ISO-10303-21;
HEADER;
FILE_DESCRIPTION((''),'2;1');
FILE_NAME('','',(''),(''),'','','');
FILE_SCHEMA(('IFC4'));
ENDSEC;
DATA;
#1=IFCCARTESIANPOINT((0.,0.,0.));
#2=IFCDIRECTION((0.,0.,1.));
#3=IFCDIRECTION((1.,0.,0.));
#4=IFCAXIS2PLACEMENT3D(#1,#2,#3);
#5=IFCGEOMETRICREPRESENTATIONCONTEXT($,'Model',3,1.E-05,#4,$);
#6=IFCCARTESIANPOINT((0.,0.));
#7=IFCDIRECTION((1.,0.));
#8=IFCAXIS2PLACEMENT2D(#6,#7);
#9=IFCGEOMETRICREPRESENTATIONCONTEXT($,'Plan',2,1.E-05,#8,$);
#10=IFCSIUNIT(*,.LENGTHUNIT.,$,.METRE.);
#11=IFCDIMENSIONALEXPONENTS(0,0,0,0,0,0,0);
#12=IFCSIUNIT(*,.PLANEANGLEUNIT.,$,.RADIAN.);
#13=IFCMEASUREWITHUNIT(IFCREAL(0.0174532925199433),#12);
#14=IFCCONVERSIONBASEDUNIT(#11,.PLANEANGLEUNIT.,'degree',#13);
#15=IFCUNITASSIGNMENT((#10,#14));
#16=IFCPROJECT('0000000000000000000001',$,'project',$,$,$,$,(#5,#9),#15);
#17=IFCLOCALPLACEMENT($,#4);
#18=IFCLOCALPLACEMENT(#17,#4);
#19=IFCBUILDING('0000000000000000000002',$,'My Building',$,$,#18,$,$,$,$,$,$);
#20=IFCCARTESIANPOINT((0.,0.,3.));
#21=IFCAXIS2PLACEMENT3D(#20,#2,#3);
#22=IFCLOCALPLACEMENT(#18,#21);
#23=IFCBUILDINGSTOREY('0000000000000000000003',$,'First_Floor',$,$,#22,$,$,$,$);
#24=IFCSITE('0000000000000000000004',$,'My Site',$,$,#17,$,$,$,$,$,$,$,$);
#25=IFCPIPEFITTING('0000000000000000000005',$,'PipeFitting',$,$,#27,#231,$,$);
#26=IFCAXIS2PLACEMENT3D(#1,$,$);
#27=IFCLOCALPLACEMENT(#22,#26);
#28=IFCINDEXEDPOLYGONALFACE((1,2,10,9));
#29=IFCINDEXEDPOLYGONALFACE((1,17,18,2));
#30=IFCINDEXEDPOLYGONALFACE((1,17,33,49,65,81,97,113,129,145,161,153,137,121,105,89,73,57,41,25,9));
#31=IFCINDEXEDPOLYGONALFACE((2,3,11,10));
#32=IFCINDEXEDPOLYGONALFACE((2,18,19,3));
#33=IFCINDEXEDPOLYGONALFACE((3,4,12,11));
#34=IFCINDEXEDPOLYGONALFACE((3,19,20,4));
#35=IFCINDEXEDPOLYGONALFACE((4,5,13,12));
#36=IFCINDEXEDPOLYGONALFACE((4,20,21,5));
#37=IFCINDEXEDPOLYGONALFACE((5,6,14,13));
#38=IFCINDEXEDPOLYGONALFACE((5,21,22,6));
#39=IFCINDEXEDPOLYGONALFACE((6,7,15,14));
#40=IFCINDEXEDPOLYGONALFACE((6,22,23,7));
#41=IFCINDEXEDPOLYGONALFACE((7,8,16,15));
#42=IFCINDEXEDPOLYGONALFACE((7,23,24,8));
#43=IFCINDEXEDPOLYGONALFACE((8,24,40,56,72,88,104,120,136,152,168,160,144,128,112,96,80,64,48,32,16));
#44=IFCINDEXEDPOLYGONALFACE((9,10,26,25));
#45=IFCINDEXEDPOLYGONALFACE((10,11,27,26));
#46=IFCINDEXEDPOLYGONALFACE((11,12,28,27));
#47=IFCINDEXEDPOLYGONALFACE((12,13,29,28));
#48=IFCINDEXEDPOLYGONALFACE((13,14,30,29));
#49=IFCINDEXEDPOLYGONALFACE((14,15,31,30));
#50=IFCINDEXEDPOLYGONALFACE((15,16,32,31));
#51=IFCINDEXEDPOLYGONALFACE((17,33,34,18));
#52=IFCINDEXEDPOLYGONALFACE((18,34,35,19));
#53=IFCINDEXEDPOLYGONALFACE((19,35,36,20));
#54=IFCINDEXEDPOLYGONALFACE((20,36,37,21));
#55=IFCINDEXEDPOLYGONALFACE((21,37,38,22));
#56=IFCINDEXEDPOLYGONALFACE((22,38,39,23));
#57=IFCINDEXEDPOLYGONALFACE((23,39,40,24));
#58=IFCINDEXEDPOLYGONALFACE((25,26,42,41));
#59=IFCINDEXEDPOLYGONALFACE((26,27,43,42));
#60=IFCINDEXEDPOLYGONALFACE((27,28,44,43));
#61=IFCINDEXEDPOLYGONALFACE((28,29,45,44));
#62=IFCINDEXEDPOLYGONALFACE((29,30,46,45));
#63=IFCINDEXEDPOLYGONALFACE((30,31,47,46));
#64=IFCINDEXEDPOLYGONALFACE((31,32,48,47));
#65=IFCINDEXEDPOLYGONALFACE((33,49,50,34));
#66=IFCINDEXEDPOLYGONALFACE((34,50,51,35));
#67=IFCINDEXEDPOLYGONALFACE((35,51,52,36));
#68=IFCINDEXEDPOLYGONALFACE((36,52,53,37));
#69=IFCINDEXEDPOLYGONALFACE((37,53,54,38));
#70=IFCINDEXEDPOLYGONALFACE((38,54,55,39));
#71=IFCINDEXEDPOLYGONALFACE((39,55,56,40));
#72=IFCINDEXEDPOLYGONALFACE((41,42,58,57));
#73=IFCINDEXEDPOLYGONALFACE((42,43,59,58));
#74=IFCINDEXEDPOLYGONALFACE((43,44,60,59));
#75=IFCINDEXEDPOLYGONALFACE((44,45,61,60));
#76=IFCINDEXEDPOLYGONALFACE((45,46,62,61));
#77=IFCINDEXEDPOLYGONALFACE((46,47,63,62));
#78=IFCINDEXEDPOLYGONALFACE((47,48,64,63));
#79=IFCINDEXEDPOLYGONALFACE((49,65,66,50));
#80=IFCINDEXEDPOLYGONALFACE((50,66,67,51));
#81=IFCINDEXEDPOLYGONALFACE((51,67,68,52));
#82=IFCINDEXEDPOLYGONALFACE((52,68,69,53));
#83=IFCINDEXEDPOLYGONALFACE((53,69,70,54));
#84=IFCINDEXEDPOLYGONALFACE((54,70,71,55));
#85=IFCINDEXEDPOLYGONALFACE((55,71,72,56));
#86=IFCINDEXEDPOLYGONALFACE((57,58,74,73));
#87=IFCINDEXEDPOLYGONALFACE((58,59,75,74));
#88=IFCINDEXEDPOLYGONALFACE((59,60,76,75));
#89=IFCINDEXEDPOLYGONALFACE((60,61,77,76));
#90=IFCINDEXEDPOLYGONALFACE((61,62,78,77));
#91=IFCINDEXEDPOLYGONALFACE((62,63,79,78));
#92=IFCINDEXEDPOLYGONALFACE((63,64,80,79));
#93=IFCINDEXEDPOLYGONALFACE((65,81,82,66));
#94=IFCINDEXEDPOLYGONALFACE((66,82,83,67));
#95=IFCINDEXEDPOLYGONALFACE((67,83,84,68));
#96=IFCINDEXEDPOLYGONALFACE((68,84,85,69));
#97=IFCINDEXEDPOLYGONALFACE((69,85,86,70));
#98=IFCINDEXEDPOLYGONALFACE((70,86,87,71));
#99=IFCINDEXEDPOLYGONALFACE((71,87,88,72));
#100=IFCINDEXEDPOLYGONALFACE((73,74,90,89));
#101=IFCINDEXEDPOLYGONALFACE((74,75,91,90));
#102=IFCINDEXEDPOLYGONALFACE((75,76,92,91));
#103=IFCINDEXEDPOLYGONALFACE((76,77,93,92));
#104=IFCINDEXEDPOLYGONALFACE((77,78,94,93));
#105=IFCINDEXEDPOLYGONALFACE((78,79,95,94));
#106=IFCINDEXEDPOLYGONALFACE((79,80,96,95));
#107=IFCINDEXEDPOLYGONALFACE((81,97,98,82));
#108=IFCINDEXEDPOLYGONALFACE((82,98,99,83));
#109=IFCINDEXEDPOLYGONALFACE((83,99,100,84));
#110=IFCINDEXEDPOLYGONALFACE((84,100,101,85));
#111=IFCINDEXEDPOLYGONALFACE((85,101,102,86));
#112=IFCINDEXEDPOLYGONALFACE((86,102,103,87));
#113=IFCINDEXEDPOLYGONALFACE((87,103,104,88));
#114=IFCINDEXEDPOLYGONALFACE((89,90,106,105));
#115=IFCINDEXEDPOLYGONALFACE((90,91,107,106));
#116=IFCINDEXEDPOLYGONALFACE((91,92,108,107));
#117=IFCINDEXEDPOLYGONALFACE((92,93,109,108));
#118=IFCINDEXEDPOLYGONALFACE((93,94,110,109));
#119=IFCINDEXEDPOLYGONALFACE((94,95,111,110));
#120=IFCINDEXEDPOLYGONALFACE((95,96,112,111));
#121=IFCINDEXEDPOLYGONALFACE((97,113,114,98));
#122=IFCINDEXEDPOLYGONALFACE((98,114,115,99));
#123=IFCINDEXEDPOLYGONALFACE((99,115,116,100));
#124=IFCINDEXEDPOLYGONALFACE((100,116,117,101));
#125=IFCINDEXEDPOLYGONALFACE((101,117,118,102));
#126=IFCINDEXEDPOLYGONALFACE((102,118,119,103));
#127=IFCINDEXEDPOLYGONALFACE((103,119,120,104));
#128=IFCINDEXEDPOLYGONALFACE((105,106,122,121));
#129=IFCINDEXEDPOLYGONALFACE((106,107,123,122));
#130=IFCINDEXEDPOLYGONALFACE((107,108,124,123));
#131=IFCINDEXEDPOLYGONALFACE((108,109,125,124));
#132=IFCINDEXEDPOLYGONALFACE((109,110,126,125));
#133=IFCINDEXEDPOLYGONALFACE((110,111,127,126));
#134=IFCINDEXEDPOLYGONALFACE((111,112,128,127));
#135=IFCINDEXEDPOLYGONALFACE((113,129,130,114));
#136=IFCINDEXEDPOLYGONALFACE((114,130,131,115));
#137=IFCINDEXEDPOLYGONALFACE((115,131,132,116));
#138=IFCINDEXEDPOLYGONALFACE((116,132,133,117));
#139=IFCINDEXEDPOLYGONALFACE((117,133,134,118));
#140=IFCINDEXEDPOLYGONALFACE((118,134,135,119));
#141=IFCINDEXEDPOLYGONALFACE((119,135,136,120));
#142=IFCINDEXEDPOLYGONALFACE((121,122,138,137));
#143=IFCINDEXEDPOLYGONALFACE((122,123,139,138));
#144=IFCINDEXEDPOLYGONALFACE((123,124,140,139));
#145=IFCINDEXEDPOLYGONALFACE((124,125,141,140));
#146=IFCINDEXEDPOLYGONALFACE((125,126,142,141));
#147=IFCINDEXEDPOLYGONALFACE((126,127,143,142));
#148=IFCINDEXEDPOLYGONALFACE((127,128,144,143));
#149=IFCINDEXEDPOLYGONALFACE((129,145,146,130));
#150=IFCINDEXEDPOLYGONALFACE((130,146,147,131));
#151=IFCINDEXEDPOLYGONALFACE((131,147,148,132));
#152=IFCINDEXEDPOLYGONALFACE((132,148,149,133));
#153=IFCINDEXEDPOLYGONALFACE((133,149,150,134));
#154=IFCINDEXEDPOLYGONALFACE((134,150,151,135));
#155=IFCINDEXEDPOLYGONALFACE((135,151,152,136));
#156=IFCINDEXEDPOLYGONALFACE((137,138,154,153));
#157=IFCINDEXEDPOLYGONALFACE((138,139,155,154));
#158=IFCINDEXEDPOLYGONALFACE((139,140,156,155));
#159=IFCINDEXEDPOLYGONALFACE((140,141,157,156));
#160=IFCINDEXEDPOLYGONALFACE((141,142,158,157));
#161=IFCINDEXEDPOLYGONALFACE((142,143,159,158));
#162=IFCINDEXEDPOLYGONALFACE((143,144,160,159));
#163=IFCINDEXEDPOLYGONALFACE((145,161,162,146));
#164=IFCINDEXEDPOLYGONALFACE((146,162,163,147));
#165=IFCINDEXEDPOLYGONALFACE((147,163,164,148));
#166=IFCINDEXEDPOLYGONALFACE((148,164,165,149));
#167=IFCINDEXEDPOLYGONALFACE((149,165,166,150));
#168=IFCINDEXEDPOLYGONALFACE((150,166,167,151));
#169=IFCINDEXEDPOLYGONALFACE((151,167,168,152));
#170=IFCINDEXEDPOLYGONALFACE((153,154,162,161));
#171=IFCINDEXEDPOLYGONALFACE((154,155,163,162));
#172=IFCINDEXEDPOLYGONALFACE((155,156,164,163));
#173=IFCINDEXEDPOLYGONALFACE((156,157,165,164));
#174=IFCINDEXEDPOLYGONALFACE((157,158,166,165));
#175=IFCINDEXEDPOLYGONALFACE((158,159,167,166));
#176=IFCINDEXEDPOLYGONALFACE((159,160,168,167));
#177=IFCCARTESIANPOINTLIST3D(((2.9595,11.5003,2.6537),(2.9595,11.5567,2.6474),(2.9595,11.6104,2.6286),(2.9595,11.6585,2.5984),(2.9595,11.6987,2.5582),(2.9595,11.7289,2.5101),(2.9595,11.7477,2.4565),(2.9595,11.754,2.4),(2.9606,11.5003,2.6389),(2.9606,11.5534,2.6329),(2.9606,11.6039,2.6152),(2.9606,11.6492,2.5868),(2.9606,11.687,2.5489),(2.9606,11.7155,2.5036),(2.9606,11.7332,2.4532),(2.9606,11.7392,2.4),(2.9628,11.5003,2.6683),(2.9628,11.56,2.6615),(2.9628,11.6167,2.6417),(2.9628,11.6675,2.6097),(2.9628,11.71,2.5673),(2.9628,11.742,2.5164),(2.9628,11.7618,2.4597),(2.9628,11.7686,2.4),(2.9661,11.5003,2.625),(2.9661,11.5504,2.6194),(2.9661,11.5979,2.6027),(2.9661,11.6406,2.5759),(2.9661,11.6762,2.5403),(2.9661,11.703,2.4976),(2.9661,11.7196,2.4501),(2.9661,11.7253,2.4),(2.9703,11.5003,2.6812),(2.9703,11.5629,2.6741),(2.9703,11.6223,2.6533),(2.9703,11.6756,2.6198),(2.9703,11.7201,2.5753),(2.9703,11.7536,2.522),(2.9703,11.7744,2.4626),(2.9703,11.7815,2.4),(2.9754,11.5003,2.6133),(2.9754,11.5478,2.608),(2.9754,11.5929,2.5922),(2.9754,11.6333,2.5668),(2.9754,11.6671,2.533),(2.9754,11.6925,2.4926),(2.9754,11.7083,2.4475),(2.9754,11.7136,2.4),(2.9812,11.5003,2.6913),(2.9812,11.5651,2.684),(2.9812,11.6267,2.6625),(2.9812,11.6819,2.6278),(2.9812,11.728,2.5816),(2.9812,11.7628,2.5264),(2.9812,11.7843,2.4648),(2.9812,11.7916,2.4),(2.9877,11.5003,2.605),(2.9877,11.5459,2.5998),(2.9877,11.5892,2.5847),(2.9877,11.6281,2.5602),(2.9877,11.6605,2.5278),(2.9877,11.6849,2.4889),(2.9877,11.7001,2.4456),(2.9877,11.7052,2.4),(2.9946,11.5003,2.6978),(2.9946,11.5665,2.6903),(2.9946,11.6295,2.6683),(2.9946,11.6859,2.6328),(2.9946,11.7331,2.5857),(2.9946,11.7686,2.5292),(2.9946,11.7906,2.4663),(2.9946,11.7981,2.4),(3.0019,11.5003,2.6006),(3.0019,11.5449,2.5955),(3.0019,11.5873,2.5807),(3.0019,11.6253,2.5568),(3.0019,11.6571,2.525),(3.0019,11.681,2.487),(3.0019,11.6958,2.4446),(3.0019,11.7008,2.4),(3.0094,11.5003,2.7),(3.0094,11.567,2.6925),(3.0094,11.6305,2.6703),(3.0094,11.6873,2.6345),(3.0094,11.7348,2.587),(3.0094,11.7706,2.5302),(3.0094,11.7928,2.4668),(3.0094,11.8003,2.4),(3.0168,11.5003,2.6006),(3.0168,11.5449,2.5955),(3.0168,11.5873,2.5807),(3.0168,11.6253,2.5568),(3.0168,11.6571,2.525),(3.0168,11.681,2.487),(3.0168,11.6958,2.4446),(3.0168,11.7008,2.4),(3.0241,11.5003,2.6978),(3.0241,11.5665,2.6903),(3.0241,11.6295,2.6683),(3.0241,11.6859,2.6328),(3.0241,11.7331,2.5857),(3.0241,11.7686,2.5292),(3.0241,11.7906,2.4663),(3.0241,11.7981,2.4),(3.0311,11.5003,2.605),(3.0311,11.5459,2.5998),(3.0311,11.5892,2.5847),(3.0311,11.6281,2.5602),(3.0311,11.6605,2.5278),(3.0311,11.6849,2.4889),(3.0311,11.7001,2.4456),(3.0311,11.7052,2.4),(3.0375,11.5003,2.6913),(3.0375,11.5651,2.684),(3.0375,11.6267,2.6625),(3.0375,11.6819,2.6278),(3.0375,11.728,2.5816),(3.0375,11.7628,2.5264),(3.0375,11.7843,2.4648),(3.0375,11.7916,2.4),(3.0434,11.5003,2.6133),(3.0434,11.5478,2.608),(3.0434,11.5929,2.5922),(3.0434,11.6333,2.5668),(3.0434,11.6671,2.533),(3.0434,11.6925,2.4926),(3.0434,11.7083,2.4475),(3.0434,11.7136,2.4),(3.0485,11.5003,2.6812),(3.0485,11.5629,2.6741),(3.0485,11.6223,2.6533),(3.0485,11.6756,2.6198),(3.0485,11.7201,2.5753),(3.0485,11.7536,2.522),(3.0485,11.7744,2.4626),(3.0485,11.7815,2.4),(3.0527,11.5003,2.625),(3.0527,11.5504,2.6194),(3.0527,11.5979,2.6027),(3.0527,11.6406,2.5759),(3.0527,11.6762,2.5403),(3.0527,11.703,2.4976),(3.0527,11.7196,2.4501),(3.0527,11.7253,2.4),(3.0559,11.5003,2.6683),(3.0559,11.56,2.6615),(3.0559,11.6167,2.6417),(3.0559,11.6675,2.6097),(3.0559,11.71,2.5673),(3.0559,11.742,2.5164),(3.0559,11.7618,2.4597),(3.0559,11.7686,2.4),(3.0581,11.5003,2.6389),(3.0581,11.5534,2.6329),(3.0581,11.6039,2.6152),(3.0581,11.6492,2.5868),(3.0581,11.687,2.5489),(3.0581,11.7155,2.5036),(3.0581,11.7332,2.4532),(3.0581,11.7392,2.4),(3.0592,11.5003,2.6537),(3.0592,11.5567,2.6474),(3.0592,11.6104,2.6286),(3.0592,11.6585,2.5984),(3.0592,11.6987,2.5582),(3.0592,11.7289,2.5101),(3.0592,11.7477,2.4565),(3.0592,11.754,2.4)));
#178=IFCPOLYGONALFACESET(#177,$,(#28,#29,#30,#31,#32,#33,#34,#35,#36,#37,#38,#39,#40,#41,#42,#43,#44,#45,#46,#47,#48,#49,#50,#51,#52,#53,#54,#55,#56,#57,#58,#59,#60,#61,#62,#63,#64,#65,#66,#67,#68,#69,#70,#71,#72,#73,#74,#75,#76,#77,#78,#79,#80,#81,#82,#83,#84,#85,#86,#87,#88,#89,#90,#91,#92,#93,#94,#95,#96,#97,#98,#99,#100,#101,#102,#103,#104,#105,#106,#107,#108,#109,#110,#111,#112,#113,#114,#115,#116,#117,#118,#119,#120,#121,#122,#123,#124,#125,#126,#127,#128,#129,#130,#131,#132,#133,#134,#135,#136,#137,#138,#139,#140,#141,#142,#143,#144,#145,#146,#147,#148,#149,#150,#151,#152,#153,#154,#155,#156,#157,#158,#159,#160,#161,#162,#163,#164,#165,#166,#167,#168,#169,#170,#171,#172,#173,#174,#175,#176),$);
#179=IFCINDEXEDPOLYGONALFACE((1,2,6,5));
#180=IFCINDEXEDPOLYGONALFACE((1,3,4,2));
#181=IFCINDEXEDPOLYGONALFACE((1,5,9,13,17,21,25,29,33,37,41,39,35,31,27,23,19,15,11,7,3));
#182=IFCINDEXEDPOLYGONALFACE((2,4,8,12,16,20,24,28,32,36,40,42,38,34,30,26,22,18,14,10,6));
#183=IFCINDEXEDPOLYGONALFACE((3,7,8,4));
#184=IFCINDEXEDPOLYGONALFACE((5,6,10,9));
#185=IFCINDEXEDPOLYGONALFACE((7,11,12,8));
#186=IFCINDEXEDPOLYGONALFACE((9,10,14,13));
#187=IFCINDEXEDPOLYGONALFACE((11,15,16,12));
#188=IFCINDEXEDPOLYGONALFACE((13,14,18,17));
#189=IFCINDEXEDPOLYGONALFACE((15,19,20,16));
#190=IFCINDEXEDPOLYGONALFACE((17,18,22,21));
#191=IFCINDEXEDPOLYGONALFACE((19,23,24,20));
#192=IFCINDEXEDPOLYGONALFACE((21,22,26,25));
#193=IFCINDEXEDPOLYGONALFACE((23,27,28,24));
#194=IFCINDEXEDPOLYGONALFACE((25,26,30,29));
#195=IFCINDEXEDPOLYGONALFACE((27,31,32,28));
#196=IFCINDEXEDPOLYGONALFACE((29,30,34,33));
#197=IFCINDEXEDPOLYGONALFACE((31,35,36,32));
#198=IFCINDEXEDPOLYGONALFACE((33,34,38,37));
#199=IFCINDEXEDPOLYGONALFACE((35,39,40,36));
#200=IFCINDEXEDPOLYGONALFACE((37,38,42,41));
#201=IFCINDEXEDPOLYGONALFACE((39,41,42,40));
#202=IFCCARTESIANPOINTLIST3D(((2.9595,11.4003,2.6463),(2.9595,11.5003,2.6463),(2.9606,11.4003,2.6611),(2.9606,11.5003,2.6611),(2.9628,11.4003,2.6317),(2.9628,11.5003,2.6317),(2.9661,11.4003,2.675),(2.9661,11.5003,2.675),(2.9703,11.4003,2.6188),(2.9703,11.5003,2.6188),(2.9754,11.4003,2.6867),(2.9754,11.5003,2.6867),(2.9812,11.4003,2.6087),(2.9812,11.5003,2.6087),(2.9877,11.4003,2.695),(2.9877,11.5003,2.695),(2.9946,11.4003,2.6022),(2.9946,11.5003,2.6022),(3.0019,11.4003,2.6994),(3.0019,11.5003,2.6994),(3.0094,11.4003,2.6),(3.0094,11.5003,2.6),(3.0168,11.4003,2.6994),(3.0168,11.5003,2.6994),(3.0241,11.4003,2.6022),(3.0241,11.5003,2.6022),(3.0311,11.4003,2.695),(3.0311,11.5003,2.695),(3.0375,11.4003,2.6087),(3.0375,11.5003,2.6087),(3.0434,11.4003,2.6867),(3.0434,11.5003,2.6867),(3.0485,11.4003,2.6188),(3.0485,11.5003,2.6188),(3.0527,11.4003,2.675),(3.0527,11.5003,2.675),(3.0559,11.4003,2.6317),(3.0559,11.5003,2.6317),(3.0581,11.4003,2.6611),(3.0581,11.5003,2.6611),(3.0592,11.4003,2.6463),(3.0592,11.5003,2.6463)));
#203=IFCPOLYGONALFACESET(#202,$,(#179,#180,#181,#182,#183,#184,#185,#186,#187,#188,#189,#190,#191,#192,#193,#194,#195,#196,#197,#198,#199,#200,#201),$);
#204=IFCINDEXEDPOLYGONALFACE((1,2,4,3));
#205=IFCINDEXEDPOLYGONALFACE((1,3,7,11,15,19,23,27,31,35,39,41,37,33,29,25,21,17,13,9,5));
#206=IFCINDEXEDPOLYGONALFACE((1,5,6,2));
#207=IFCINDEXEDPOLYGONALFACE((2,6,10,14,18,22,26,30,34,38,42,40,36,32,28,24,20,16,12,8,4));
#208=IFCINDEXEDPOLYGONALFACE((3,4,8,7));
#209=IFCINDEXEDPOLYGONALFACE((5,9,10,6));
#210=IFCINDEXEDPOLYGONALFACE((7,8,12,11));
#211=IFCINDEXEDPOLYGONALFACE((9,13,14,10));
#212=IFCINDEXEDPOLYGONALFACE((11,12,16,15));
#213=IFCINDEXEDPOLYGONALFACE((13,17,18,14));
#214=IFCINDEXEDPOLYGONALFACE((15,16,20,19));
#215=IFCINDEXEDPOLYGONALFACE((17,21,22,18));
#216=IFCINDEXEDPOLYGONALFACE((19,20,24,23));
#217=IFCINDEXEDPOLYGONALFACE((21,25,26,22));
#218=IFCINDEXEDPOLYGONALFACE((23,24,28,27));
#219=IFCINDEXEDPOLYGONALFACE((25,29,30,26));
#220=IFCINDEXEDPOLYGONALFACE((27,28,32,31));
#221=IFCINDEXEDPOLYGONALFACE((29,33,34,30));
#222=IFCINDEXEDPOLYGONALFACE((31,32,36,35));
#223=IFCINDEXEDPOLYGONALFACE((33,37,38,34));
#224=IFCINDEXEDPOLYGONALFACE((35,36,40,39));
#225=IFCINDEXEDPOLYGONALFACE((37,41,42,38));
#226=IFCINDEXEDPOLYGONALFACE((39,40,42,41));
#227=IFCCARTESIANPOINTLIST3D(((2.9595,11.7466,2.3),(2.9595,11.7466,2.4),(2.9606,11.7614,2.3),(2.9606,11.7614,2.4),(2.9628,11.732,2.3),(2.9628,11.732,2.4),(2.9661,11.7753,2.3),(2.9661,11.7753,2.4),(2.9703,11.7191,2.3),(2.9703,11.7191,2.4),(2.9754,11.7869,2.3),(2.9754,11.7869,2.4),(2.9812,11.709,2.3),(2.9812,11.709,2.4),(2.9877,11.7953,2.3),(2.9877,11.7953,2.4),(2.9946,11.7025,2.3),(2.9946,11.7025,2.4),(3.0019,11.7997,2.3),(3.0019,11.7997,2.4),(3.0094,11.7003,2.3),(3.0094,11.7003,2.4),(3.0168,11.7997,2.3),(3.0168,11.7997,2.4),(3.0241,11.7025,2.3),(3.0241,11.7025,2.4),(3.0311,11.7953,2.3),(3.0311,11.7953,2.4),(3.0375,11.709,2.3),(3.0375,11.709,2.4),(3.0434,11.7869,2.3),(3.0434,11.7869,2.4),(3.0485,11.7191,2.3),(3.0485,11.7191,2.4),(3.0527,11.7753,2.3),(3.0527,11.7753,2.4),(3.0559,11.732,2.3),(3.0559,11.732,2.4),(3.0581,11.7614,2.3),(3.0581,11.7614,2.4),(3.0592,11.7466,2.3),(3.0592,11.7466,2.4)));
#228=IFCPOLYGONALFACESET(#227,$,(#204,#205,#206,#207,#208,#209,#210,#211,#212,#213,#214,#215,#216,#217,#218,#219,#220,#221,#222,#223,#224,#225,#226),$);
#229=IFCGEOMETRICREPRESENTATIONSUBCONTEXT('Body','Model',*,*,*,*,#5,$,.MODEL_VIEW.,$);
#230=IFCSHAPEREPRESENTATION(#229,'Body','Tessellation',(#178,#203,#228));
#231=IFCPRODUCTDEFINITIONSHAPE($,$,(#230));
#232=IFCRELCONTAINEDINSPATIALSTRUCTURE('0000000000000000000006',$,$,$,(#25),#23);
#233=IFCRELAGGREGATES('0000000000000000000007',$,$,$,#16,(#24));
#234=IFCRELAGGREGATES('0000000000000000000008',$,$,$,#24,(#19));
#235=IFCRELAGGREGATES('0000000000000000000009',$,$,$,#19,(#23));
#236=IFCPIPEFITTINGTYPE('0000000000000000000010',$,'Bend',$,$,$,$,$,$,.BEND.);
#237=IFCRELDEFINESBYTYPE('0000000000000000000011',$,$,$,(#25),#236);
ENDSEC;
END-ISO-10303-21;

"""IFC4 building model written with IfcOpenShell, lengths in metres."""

from ifc_helpers import new_model, entity, si_unit, converted_unit, frame, origin_with_axes, origin_2d_with_axis, place, context, subcontext, project, spatial, circle, extrude, source, transform, mapped, type_object, type_shapes, element, save


model = new_model("IFC4")

# Units and contexts
model_context = context("Model", 3, precision=1e-05, world=origin_with_axes())
plan_context = context("Plan", 2, precision=1e-05, world=origin_2d_with_axis())
body_context = subcontext(model_context, "Body", "Model", "MODEL_VIEW")
ifc_project = project(units=[si_unit("LENGTHUNIT", "METRE"), converted_unit("PLANEANGLEUNIT", "degree", entity("IfcReal", 0.0174532925199433), si_unit("PLANEANGLEUNIT", "RADIAN"), dimensions=[0, 0, 0, 0, 0, 0, 0])], contexts=[model_context, plan_context])

# Site, building, storey
site_placement = place(None, origin_with_axes())
site = spatial("IfcSite", under=ifc_project, at=site_placement, Name="My Site")
building_placement = place(site_placement, origin_with_axes())
building = spatial("IfcBuilding", under=site, at=building_placement, Name="My Building")
storey_placement = place(building_placement, frame((0.0, 0.0, 3.0), z_axis=(0.0, 0.0, 1.0), x_axis=(1.0, 0.0, 0.0)))
storey = spatial("IfcBuildingStorey", under=building, at=storey_placement, Name="First_Floor")

# Pipe fitting
pipe_fitting_type = type_object("IfcPipeFittingType", Name="Bend", PredefinedType="BEND")
shared_shape = source(origin_with_axes(), body_context, "Body", "SolidModel", [
    entity("IfcSweptDiskSolid", entity("IfcIndexedPolyCurve", entity("IfcCartesianPointList3D", [[0.0, 0.0, -0.1], [0.0732, 0.0, -0.2768], [0.25, 0.0, -0.35]]), [entity("IfcArcIndex", [1, 2, 3])]), 0.05),
    extrude(circle(Radius=0.05), origin_with_axes(), (0.0, 0.0, -1.0), 0.1),
    extrude(circle(Radius=0.05), frame((0.25, 0.0, -0.35), z_axis=(1.0, 0.0, 0.0), x_axis=(0.0, 0.0, 1.0)), (0.0, 0.0, 1.0), 0.1),
])
type_shapes(pipe_fitting_type, [shared_shape])
for number, where, z_axis, x_axis, name in (
    (1, (3.0094, 11.4003, 2.65), (0.0, -1.0, 0.0), (0.0, 0.0, -1.0), "PipeFitting"),
):
    element("IfcPipeFitting", number, at=place(storey_placement, frame(where, z_axis=z_axis, x_axis=x_axis)), inside=storey, type_object=pipe_fitting_type, Name=name, context=body_context, shape_type="MappedRepresentation", body=[
        mapped(shared_shape, transform((0.0, 0.0, 0.0), x_axis=(1.0, 0.0, 0.0), y_axis=(0.0, 1.0, 0.0), z_axis=(0.0, 0.0, 1.0), scale=1.0)),
    ])

save(model, "model.ifc")
